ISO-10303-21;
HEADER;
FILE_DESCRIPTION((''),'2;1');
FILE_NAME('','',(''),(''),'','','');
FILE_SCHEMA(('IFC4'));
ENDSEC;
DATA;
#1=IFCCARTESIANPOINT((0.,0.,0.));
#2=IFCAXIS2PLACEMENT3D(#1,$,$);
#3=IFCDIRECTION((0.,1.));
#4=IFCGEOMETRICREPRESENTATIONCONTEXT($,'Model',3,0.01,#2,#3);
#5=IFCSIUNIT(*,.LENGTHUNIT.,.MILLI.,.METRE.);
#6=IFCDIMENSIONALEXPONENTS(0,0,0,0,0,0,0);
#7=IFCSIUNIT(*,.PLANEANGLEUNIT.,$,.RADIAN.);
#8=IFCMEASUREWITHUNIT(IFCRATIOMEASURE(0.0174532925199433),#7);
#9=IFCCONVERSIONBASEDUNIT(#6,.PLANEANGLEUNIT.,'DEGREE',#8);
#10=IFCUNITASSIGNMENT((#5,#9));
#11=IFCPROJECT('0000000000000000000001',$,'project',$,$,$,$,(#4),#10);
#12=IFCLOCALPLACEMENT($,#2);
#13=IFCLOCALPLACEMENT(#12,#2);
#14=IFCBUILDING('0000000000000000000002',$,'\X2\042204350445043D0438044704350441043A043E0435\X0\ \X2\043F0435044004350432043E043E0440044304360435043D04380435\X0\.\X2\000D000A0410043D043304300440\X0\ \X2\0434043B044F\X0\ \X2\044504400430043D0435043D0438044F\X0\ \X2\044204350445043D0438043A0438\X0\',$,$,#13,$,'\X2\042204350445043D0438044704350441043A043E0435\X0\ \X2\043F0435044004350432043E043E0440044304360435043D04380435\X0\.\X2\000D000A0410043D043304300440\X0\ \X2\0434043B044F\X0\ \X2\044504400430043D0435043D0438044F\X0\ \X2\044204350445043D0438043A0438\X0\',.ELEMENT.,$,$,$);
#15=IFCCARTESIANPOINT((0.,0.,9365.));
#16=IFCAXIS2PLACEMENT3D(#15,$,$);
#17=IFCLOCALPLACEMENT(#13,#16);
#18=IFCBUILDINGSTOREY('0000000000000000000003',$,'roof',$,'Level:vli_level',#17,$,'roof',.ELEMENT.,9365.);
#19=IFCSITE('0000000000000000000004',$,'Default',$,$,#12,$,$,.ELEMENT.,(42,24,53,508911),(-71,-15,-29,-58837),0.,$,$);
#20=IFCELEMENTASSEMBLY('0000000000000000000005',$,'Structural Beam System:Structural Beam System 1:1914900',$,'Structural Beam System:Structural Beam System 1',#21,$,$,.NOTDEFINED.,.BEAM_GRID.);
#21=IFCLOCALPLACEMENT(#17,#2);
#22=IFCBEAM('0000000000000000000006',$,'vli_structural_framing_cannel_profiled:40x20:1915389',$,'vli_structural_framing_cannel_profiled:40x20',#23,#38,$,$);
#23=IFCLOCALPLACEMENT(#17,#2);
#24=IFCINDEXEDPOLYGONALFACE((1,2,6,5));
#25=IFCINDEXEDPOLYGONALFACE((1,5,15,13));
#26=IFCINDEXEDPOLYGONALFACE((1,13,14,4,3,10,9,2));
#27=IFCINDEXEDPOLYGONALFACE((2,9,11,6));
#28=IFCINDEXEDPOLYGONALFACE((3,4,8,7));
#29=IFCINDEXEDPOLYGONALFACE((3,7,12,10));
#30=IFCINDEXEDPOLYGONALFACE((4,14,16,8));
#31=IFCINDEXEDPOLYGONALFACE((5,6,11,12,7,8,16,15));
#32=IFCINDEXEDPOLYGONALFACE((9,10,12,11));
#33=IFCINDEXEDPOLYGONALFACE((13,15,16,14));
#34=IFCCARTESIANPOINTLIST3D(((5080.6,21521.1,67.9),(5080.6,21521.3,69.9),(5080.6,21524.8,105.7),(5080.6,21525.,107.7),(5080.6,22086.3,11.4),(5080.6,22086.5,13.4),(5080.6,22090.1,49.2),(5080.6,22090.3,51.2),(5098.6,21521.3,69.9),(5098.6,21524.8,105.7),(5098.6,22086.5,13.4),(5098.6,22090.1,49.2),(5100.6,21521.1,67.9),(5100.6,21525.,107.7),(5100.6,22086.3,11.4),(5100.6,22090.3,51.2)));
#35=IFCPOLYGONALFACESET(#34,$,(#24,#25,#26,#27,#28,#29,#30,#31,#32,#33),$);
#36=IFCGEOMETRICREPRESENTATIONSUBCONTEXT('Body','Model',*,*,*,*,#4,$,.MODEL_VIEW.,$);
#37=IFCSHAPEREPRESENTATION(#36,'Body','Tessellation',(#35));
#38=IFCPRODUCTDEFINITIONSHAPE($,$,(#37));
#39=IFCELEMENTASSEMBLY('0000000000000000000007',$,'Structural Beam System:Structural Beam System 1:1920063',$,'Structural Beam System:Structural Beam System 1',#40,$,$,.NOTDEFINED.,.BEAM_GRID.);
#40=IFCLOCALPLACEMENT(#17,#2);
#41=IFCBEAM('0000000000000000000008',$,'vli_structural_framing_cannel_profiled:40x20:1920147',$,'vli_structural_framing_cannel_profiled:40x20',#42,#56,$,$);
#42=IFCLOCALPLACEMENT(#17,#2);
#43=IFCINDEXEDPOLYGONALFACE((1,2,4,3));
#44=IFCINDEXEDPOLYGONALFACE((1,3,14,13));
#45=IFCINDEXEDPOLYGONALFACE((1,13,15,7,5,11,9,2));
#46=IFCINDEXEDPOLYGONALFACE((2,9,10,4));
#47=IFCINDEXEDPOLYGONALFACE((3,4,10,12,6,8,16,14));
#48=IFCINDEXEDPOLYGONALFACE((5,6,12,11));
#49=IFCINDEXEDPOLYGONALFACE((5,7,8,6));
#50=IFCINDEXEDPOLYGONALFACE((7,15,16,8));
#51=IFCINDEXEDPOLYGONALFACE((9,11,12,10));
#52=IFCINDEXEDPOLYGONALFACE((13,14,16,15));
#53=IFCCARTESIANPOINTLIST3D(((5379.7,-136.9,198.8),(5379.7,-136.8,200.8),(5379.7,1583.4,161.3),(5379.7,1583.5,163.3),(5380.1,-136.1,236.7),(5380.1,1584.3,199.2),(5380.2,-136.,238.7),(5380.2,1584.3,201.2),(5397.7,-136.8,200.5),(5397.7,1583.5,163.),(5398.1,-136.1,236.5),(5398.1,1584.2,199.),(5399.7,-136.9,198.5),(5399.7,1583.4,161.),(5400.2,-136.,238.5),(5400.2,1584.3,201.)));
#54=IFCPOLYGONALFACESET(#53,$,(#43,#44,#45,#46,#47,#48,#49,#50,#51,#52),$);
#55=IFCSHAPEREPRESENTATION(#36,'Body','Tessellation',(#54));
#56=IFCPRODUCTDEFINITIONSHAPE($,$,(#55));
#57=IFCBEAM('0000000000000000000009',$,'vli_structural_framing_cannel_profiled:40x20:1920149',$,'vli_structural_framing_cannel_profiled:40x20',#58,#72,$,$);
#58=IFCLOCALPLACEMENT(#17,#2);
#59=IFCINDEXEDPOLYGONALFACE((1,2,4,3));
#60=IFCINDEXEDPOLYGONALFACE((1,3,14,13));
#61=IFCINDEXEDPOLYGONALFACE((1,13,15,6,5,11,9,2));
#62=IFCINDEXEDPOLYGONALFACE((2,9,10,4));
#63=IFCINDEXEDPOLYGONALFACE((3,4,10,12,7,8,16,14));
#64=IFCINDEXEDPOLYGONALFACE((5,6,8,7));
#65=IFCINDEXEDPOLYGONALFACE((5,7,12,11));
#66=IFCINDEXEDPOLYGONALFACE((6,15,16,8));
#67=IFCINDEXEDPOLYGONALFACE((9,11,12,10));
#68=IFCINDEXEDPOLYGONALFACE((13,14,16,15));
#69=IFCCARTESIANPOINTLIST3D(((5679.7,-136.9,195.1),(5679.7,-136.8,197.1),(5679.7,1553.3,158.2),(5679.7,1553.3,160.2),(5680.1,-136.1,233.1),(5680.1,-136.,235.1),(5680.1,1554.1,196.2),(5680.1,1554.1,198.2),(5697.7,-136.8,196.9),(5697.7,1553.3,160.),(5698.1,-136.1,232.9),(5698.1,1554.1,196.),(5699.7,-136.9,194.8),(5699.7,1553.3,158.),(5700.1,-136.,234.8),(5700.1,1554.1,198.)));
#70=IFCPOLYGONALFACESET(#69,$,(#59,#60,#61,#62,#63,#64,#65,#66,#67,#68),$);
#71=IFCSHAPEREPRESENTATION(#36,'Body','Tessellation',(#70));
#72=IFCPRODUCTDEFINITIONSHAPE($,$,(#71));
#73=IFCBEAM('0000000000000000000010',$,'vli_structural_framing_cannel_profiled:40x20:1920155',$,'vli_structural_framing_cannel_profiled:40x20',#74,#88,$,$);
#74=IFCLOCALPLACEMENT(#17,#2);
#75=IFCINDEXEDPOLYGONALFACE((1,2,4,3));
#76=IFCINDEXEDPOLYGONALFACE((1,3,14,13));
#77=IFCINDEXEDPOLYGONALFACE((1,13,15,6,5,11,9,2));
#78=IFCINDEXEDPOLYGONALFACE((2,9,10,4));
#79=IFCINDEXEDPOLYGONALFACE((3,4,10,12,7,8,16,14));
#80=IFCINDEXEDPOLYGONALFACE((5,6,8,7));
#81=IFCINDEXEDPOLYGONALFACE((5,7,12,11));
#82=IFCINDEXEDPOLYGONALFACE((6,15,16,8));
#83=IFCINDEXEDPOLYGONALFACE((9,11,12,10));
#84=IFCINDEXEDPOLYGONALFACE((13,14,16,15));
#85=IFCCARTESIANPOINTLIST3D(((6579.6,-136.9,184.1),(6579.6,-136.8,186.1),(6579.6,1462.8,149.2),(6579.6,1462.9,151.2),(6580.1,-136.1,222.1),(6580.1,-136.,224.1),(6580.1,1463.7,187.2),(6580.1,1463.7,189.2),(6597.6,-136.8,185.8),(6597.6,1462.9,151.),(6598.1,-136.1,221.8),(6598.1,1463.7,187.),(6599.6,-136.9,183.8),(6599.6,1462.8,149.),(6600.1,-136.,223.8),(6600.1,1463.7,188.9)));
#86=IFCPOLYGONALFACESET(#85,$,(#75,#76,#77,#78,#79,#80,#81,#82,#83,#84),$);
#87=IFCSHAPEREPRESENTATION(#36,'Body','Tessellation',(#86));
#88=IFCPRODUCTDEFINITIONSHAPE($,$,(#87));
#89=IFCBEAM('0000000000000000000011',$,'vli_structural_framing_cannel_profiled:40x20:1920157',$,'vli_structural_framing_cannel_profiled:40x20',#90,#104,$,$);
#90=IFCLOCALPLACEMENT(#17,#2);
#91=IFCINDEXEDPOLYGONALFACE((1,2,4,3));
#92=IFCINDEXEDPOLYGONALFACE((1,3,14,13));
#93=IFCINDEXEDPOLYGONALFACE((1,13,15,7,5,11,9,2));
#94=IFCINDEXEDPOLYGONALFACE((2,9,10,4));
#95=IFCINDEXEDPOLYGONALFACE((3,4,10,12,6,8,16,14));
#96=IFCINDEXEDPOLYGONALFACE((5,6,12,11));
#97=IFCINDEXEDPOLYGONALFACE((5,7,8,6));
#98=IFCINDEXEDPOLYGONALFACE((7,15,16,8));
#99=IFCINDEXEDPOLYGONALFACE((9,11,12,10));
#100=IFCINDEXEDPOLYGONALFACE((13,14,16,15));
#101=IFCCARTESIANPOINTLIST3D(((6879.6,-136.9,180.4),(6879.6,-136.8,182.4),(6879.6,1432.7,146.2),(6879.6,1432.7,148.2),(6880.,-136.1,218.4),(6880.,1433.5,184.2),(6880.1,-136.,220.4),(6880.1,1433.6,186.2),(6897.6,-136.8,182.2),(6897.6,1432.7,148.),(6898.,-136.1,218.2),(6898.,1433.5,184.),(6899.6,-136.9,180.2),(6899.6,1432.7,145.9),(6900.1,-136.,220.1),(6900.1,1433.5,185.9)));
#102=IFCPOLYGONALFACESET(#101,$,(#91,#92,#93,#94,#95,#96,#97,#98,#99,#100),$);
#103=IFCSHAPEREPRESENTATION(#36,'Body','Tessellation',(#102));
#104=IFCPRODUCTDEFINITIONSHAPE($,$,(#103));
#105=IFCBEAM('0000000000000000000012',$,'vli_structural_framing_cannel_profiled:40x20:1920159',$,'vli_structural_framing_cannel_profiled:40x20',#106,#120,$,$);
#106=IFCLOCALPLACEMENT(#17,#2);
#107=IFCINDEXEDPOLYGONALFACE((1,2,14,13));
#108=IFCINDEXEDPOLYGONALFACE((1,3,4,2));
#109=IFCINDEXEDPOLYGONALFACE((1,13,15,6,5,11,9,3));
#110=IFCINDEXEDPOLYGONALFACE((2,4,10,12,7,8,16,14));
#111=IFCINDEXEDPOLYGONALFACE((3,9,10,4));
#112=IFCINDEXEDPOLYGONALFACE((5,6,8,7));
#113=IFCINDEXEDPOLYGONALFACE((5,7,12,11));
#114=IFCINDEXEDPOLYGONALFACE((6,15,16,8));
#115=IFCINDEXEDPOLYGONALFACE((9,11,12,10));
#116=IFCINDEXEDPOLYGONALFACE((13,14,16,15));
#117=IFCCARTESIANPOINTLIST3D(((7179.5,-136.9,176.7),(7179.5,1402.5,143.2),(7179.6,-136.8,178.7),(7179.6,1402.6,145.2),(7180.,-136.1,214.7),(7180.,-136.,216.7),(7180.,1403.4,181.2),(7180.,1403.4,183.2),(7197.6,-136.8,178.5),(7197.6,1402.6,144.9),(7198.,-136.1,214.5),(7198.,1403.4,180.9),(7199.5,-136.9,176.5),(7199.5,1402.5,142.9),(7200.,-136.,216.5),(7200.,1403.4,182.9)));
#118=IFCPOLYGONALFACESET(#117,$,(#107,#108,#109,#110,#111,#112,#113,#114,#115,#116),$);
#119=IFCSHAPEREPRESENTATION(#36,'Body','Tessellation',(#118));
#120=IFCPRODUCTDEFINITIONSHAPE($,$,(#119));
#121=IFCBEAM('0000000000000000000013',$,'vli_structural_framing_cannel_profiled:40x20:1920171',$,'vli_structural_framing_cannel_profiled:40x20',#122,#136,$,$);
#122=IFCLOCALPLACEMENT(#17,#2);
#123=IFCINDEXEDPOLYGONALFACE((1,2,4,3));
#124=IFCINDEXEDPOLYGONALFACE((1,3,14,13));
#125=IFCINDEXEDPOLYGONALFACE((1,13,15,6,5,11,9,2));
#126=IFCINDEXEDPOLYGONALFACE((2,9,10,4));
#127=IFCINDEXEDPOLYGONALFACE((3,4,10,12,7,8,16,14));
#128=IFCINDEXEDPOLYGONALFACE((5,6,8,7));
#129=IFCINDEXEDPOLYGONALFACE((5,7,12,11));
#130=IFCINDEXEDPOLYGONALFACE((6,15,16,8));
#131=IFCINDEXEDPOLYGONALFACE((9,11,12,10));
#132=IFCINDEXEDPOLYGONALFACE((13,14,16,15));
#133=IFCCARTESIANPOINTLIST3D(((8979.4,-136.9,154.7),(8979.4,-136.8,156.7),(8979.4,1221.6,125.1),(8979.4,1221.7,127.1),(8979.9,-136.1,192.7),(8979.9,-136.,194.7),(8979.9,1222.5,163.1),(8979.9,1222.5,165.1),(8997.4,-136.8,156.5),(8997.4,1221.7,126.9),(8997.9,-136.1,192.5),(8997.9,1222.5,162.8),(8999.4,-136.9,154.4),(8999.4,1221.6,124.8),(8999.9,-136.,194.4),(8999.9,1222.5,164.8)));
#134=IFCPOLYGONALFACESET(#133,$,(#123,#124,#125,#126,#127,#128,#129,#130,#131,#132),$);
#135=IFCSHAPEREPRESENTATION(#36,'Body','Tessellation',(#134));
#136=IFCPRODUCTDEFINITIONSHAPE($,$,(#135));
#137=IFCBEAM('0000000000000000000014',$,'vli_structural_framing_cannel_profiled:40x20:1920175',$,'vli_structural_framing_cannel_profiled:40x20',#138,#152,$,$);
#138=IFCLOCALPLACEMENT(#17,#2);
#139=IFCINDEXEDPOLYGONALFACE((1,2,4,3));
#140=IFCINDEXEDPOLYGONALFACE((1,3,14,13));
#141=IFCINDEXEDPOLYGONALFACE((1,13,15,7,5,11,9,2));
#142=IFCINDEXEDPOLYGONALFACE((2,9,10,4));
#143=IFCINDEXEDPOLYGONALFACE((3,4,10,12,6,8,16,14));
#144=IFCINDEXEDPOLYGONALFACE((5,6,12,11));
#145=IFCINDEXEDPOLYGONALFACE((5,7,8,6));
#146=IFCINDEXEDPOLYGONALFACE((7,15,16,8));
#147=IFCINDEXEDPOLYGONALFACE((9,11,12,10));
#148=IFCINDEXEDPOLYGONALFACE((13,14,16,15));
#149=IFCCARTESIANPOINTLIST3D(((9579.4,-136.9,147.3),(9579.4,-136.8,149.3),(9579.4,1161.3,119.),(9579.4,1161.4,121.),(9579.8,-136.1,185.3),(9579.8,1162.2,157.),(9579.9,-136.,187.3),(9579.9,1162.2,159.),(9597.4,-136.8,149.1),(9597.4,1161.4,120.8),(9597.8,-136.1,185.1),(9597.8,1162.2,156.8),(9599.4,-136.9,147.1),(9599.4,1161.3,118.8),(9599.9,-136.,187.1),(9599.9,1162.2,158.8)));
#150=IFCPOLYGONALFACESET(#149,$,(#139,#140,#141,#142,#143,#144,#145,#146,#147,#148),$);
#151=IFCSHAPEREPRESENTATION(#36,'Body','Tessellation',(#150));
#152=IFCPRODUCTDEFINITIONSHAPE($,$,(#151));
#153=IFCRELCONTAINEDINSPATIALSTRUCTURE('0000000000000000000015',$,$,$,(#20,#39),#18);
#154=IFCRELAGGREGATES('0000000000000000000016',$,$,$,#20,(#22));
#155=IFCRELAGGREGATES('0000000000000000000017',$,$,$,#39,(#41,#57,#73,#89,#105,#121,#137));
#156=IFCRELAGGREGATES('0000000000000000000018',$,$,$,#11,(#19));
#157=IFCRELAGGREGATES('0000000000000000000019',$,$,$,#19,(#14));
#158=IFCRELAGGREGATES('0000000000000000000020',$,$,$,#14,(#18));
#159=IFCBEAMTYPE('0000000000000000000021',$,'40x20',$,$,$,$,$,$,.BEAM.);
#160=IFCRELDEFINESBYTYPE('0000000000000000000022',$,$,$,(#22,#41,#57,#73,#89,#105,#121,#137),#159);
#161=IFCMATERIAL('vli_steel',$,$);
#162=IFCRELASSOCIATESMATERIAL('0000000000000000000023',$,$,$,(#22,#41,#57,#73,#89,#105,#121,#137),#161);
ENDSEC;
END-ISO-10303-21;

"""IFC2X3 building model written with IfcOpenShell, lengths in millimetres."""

from ifc_helpers import new_model, entity, si_unit, converted_unit, direction, frame, origin, place, context, subcontext, project, spatial, polyline, outline, extrude, material, type_object, element, aggregate, save


model = new_model("IFC2X3")

# Units and contexts
model_context = context("Model", 3, precision=0.01, world=origin(), true_north=direction((0.0, 1.0)))
body_context = subcontext(model_context, "Body", "Model", "MODEL_VIEW")
ifc_project = project(units=[si_unit("LENGTHUNIT", "METRE", prefix="MILLI"), converted_unit("PLANEANGLEUNIT", "DEGREE", entity("IfcRatioMeasure", 0.0174532925199433), si_unit("PLANEANGLEUNIT", "RADIAN"), dimensions=[0, 0, 0, 0, 0, 0, 0])], contexts=[model_context])

# Site, building, storey
site_placement = place(None, origin())
site = spatial("IfcSite", under=ifc_project, at=site_placement, Name="Default", CompositionType="ELEMENT", RefLatitude=(42, 24, 53, 508911), RefLongitude=(-71, -15, -29, -58837), RefElevation=0.0)
building_placement = place(site_placement, origin())
building = spatial("IfcBuilding", under=site, at=building_placement, Name="Техническое перевооружение.\r\nАнгар для хранения техники", LongName="Техническое перевооружение.\r\nАнгар для хранения техники", CompositionType="ELEMENT")
storey_placement = place(building_placement, frame((0.0, 0.0, 9365.0)))
storey = spatial("IfcBuildingStorey", under=building, at=storey_placement, Name="roof", ObjectType="Level:vli_level", LongName="roof", CompositionType="ELEMENT", Elevation=9365.0)

# Element assemblies, beams
ifc_material = material(Name="vli_steel")
beam_type = type_object("IfcBeamType", Name="40x20", PredefinedType="BEAM")
assembly_1_placement = place(storey_placement, origin())
assembly_1 = element("IfcElementAssembly", 1, at=assembly_1_placement, inside=storey, Name="Structural Beam System:Structural Beam System 1:1914900", ObjectType="Structural Beam System:Structural Beam System 1", AssemblyPlace="NOTDEFINED", PredefinedType="BEAM_GRID")
beam_1_placement = place(assembly_1_placement, frame((5100.0, 22090.8, 10.9), z_axis=(0.0, 0.099504, 0.995037), x_axis=(0.0, -0.995037, 0.099504)))
beam_1 = element("IfcBeam", 2, at=beam_1_placement, type_object=beam_type, material=ifc_material, Name="vli_structural_framing_cannel_profiled:40x20:1915389", ObjectType="vli_structural_framing_cannel_profiled:40x20", context=body_context, shape_type="SweptSolid", body=[
    extrude(outline(polyline([(-20.0, -9.5), (-18.0, -9.5), (-18.0, 8.5), (18.0, 8.5), (18.0, -9.5), (20.0, -9.5), (20.0, 10.5), (-20.0, 10.5), (-20.0, -9.5)])), frame((4.6, -9.9, 20.0), z_axis=(1.0, 0.0, 0.0), x_axis=(0.0, 0.0, -1.0)), (0.0, 0.0, 1.0), 568.0),
])
aggregate(assembly_1, [beam_1])
assembly_2_placement = place(storey_placement, origin())
assembly_2 = element("IfcElementAssembly", 3, at=assembly_2_placement, inside=storey, Name="Structural Beam System:Structural Beam System 1:1920063", ObjectType="Structural Beam System:Structural Beam System 1", AssemblyPlace="NOTDEFINED", PredefinedType="BEAM_GRID")
beam_2_placement = place(assembly_2_placement, frame((5399.6, 1597.6, 200.7), z_axis=(0.0, 0.021793, 0.999763), x_axis=(0.0, -0.999763, 0.021793)))
beam_2 = element("IfcBeam", 4, at=beam_2_placement, type_object=beam_type, material=ifc_material, Name="vli_structural_framing_cannel_profiled:40x20:1920147", ObjectType="vli_structural_framing_cannel_profiled:40x20", context=body_context, shape_type="SweptSolid", body=[
    extrude(outline(polyline([(-10.5, -20.0), (9.5, -20.0), (9.5, -18.0), (-8.5, -18.0), (-8.5, 18.0), (9.5, 18.0), (9.5, 20.0), (-10.5, 20.0), (-10.5, -20.0)])), frame((13.4, -10.1, -19.9), z_axis=(1.0, 0.0, 0.0), x_axis=(0.0, -0.999925, 0.012237)), (0.0, 0.0, 1.0), 1720.7),
])
beam_3_placement = place(assembly_2_placement, frame((5699.5, 1567.5, 197.7), z_axis=(0.0, 0.021793, 0.999763), x_axis=(0.0, -0.999763, 0.021793)))
beam_3 = element("IfcBeam", 5, at=beam_3_placement, type_object=beam_type, material=ifc_material, Name="vli_structural_framing_cannel_profiled:40x20:1920149", ObjectType="vli_structural_framing_cannel_profiled:40x20", context=body_context, shape_type="SweptSolid", body=[
    extrude(outline(polyline([(-10.5, -20.0), (9.5, -20.0), (9.5, -18.0), (-8.5, -18.0), (-8.5, 18.0), (9.5, 18.0), (9.5, 20.0), (-10.5, 20.0), (-10.5, -20.0)])), frame((13.4, -10.1, -19.9), z_axis=(1.0, 0.0, 0.0), x_axis=(0.0, -0.999925, 0.012237)), (0.0, 0.0, 1.0), 1690.6),
])
beam_4_placement = place(assembly_2_placement, frame((6599.5, 1477.1, 188.7), z_axis=(0.0, 0.021793, 0.999763), x_axis=(0.0, -0.999763, 0.021793)))
beam_4 = element("IfcBeam", 6, at=beam_4_placement, type_object=beam_type, material=ifc_material, Name="vli_structural_framing_cannel_profiled:40x20:1920155", ObjectType="vli_structural_framing_cannel_profiled:40x20", context=body_context, shape_type="SweptSolid", body=[
    extrude(outline(polyline([(-10.5, -20.0), (9.5, -20.0), (9.5, -18.0), (-8.5, -18.0), (-8.5, 18.0), (9.5, 18.0), (9.5, 20.0), (-10.5, 20.0), (-10.5, -20.0)])), frame((13.4, -10.1, -19.9), z_axis=(1.0, 0.0, 0.0), x_axis=(0.0, -0.999925, 0.012237)), (0.0, 0.0, 1.0), 1600.1),
])
beam_5_placement = place(assembly_2_placement, frame((6899.5, 1446.9, 185.6), z_axis=(0.0, 0.021793, 0.999763), x_axis=(0.0, -0.999763, 0.021793)))
beam_5 = element("IfcBeam", 7, at=beam_5_placement, type_object=beam_type, material=ifc_material, Name="vli_structural_framing_cannel_profiled:40x20:1920157", ObjectType="vli_structural_framing_cannel_profiled:40x20", context=body_context, shape_type="SweptSolid", body=[
    extrude(outline(polyline([(-10.5, -20.0), (9.5, -20.0), (9.5, -18.0), (-8.5, -18.0), (-8.5, 18.0), (9.5, 18.0), (9.5, 20.0), (-10.5, 20.0), (-10.5, -20.0)])), frame((13.4, -10.1, -19.9), z_axis=(1.0, 0.0, 0.0), x_axis=(0.0, -0.999925, 0.012237)), (0.0, 0.0, 1.0), 1569.9),
])
beam_6_placement = place(assembly_2_placement, frame((7199.4, 1416.8, 182.6), z_axis=(0.0, 0.021793, 0.999763), x_axis=(0.0, -0.999763, 0.021793)))
beam_6 = element("IfcBeam", 8, at=beam_6_placement, type_object=beam_type, material=ifc_material, Name="vli_structural_framing_cannel_profiled:40x20:1920159", ObjectType="vli_structural_framing_cannel_profiled:40x20", context=body_context, shape_type="SweptSolid", body=[
    extrude(outline(polyline([(-10.5, -20.0), (9.5, -20.0), (9.5, -18.0), (-8.5, -18.0), (-8.5, 18.0), (9.5, 18.0), (9.5, 20.0), (-10.5, 20.0), (-10.5, -20.0)])), frame((13.4, -10.1, -19.9), z_axis=(1.0, 0.0, 0.0), x_axis=(0.0, -0.999925, 0.012237)), (0.0, 0.0, 1.0), 1539.8),
])
beam_7_placement = place(assembly_2_placement, frame((8999.3, 1235.9, 164.5), z_axis=(0.0, 0.021793, 0.999763), x_axis=(0.0, -0.999763, 0.021793)))
beam_7 = element("IfcBeam", 9, at=beam_7_placement, type_object=beam_type, material=ifc_material, Name="vli_structural_framing_cannel_profiled:40x20:1920171", ObjectType="vli_structural_framing_cannel_profiled:40x20", context=body_context, shape_type="SweptSolid", body=[
    extrude(outline(polyline([(-10.5, -20.0), (9.5, -20.0), (9.5, -18.0), (-8.5, -18.0), (-8.5, 18.0), (9.5, 18.0), (9.5, 20.0), (-10.5, 20.0), (-10.5, -20.0)])), frame((13.4, -10.1, -19.9), z_axis=(1.0, 0.0, 0.0), x_axis=(0.0, -0.999925, 0.012237)), (0.0, 0.0, 1.0), 1358.8),
])
beam_8_placement = place(assembly_2_placement, frame((9599.3, 1175.6, 158.5), z_axis=(0.0, 0.021793, 0.999763), x_axis=(0.0, -0.999763, 0.021793)))
beam_8 = element("IfcBeam", 10, at=beam_8_placement, type_object=beam_type, material=ifc_material, Name="vli_structural_framing_cannel_profiled:40x20:1920175", ObjectType="vli_structural_framing_cannel_profiled:40x20", context=body_context, shape_type="SweptSolid", body=[
    extrude(outline(polyline([(-10.5, -20.0), (9.5, -20.0), (9.5, -18.0), (-8.5, -18.0), (-8.5, 18.0), (9.5, 18.0), (9.5, 20.0), (-10.5, 20.0), (-10.5, -20.0)])), frame((13.4, -10.1, -19.9), z_axis=(1.0, 0.0, 0.0), x_axis=(0.0, -0.999925, 0.012237)), (0.0, 0.0, 1.0), 1298.5),
])
aggregate(assembly_2, [beam_2, beam_3, beam_4, beam_5, beam_6, beam_7, beam_8])

save(model, "model.ifc")
